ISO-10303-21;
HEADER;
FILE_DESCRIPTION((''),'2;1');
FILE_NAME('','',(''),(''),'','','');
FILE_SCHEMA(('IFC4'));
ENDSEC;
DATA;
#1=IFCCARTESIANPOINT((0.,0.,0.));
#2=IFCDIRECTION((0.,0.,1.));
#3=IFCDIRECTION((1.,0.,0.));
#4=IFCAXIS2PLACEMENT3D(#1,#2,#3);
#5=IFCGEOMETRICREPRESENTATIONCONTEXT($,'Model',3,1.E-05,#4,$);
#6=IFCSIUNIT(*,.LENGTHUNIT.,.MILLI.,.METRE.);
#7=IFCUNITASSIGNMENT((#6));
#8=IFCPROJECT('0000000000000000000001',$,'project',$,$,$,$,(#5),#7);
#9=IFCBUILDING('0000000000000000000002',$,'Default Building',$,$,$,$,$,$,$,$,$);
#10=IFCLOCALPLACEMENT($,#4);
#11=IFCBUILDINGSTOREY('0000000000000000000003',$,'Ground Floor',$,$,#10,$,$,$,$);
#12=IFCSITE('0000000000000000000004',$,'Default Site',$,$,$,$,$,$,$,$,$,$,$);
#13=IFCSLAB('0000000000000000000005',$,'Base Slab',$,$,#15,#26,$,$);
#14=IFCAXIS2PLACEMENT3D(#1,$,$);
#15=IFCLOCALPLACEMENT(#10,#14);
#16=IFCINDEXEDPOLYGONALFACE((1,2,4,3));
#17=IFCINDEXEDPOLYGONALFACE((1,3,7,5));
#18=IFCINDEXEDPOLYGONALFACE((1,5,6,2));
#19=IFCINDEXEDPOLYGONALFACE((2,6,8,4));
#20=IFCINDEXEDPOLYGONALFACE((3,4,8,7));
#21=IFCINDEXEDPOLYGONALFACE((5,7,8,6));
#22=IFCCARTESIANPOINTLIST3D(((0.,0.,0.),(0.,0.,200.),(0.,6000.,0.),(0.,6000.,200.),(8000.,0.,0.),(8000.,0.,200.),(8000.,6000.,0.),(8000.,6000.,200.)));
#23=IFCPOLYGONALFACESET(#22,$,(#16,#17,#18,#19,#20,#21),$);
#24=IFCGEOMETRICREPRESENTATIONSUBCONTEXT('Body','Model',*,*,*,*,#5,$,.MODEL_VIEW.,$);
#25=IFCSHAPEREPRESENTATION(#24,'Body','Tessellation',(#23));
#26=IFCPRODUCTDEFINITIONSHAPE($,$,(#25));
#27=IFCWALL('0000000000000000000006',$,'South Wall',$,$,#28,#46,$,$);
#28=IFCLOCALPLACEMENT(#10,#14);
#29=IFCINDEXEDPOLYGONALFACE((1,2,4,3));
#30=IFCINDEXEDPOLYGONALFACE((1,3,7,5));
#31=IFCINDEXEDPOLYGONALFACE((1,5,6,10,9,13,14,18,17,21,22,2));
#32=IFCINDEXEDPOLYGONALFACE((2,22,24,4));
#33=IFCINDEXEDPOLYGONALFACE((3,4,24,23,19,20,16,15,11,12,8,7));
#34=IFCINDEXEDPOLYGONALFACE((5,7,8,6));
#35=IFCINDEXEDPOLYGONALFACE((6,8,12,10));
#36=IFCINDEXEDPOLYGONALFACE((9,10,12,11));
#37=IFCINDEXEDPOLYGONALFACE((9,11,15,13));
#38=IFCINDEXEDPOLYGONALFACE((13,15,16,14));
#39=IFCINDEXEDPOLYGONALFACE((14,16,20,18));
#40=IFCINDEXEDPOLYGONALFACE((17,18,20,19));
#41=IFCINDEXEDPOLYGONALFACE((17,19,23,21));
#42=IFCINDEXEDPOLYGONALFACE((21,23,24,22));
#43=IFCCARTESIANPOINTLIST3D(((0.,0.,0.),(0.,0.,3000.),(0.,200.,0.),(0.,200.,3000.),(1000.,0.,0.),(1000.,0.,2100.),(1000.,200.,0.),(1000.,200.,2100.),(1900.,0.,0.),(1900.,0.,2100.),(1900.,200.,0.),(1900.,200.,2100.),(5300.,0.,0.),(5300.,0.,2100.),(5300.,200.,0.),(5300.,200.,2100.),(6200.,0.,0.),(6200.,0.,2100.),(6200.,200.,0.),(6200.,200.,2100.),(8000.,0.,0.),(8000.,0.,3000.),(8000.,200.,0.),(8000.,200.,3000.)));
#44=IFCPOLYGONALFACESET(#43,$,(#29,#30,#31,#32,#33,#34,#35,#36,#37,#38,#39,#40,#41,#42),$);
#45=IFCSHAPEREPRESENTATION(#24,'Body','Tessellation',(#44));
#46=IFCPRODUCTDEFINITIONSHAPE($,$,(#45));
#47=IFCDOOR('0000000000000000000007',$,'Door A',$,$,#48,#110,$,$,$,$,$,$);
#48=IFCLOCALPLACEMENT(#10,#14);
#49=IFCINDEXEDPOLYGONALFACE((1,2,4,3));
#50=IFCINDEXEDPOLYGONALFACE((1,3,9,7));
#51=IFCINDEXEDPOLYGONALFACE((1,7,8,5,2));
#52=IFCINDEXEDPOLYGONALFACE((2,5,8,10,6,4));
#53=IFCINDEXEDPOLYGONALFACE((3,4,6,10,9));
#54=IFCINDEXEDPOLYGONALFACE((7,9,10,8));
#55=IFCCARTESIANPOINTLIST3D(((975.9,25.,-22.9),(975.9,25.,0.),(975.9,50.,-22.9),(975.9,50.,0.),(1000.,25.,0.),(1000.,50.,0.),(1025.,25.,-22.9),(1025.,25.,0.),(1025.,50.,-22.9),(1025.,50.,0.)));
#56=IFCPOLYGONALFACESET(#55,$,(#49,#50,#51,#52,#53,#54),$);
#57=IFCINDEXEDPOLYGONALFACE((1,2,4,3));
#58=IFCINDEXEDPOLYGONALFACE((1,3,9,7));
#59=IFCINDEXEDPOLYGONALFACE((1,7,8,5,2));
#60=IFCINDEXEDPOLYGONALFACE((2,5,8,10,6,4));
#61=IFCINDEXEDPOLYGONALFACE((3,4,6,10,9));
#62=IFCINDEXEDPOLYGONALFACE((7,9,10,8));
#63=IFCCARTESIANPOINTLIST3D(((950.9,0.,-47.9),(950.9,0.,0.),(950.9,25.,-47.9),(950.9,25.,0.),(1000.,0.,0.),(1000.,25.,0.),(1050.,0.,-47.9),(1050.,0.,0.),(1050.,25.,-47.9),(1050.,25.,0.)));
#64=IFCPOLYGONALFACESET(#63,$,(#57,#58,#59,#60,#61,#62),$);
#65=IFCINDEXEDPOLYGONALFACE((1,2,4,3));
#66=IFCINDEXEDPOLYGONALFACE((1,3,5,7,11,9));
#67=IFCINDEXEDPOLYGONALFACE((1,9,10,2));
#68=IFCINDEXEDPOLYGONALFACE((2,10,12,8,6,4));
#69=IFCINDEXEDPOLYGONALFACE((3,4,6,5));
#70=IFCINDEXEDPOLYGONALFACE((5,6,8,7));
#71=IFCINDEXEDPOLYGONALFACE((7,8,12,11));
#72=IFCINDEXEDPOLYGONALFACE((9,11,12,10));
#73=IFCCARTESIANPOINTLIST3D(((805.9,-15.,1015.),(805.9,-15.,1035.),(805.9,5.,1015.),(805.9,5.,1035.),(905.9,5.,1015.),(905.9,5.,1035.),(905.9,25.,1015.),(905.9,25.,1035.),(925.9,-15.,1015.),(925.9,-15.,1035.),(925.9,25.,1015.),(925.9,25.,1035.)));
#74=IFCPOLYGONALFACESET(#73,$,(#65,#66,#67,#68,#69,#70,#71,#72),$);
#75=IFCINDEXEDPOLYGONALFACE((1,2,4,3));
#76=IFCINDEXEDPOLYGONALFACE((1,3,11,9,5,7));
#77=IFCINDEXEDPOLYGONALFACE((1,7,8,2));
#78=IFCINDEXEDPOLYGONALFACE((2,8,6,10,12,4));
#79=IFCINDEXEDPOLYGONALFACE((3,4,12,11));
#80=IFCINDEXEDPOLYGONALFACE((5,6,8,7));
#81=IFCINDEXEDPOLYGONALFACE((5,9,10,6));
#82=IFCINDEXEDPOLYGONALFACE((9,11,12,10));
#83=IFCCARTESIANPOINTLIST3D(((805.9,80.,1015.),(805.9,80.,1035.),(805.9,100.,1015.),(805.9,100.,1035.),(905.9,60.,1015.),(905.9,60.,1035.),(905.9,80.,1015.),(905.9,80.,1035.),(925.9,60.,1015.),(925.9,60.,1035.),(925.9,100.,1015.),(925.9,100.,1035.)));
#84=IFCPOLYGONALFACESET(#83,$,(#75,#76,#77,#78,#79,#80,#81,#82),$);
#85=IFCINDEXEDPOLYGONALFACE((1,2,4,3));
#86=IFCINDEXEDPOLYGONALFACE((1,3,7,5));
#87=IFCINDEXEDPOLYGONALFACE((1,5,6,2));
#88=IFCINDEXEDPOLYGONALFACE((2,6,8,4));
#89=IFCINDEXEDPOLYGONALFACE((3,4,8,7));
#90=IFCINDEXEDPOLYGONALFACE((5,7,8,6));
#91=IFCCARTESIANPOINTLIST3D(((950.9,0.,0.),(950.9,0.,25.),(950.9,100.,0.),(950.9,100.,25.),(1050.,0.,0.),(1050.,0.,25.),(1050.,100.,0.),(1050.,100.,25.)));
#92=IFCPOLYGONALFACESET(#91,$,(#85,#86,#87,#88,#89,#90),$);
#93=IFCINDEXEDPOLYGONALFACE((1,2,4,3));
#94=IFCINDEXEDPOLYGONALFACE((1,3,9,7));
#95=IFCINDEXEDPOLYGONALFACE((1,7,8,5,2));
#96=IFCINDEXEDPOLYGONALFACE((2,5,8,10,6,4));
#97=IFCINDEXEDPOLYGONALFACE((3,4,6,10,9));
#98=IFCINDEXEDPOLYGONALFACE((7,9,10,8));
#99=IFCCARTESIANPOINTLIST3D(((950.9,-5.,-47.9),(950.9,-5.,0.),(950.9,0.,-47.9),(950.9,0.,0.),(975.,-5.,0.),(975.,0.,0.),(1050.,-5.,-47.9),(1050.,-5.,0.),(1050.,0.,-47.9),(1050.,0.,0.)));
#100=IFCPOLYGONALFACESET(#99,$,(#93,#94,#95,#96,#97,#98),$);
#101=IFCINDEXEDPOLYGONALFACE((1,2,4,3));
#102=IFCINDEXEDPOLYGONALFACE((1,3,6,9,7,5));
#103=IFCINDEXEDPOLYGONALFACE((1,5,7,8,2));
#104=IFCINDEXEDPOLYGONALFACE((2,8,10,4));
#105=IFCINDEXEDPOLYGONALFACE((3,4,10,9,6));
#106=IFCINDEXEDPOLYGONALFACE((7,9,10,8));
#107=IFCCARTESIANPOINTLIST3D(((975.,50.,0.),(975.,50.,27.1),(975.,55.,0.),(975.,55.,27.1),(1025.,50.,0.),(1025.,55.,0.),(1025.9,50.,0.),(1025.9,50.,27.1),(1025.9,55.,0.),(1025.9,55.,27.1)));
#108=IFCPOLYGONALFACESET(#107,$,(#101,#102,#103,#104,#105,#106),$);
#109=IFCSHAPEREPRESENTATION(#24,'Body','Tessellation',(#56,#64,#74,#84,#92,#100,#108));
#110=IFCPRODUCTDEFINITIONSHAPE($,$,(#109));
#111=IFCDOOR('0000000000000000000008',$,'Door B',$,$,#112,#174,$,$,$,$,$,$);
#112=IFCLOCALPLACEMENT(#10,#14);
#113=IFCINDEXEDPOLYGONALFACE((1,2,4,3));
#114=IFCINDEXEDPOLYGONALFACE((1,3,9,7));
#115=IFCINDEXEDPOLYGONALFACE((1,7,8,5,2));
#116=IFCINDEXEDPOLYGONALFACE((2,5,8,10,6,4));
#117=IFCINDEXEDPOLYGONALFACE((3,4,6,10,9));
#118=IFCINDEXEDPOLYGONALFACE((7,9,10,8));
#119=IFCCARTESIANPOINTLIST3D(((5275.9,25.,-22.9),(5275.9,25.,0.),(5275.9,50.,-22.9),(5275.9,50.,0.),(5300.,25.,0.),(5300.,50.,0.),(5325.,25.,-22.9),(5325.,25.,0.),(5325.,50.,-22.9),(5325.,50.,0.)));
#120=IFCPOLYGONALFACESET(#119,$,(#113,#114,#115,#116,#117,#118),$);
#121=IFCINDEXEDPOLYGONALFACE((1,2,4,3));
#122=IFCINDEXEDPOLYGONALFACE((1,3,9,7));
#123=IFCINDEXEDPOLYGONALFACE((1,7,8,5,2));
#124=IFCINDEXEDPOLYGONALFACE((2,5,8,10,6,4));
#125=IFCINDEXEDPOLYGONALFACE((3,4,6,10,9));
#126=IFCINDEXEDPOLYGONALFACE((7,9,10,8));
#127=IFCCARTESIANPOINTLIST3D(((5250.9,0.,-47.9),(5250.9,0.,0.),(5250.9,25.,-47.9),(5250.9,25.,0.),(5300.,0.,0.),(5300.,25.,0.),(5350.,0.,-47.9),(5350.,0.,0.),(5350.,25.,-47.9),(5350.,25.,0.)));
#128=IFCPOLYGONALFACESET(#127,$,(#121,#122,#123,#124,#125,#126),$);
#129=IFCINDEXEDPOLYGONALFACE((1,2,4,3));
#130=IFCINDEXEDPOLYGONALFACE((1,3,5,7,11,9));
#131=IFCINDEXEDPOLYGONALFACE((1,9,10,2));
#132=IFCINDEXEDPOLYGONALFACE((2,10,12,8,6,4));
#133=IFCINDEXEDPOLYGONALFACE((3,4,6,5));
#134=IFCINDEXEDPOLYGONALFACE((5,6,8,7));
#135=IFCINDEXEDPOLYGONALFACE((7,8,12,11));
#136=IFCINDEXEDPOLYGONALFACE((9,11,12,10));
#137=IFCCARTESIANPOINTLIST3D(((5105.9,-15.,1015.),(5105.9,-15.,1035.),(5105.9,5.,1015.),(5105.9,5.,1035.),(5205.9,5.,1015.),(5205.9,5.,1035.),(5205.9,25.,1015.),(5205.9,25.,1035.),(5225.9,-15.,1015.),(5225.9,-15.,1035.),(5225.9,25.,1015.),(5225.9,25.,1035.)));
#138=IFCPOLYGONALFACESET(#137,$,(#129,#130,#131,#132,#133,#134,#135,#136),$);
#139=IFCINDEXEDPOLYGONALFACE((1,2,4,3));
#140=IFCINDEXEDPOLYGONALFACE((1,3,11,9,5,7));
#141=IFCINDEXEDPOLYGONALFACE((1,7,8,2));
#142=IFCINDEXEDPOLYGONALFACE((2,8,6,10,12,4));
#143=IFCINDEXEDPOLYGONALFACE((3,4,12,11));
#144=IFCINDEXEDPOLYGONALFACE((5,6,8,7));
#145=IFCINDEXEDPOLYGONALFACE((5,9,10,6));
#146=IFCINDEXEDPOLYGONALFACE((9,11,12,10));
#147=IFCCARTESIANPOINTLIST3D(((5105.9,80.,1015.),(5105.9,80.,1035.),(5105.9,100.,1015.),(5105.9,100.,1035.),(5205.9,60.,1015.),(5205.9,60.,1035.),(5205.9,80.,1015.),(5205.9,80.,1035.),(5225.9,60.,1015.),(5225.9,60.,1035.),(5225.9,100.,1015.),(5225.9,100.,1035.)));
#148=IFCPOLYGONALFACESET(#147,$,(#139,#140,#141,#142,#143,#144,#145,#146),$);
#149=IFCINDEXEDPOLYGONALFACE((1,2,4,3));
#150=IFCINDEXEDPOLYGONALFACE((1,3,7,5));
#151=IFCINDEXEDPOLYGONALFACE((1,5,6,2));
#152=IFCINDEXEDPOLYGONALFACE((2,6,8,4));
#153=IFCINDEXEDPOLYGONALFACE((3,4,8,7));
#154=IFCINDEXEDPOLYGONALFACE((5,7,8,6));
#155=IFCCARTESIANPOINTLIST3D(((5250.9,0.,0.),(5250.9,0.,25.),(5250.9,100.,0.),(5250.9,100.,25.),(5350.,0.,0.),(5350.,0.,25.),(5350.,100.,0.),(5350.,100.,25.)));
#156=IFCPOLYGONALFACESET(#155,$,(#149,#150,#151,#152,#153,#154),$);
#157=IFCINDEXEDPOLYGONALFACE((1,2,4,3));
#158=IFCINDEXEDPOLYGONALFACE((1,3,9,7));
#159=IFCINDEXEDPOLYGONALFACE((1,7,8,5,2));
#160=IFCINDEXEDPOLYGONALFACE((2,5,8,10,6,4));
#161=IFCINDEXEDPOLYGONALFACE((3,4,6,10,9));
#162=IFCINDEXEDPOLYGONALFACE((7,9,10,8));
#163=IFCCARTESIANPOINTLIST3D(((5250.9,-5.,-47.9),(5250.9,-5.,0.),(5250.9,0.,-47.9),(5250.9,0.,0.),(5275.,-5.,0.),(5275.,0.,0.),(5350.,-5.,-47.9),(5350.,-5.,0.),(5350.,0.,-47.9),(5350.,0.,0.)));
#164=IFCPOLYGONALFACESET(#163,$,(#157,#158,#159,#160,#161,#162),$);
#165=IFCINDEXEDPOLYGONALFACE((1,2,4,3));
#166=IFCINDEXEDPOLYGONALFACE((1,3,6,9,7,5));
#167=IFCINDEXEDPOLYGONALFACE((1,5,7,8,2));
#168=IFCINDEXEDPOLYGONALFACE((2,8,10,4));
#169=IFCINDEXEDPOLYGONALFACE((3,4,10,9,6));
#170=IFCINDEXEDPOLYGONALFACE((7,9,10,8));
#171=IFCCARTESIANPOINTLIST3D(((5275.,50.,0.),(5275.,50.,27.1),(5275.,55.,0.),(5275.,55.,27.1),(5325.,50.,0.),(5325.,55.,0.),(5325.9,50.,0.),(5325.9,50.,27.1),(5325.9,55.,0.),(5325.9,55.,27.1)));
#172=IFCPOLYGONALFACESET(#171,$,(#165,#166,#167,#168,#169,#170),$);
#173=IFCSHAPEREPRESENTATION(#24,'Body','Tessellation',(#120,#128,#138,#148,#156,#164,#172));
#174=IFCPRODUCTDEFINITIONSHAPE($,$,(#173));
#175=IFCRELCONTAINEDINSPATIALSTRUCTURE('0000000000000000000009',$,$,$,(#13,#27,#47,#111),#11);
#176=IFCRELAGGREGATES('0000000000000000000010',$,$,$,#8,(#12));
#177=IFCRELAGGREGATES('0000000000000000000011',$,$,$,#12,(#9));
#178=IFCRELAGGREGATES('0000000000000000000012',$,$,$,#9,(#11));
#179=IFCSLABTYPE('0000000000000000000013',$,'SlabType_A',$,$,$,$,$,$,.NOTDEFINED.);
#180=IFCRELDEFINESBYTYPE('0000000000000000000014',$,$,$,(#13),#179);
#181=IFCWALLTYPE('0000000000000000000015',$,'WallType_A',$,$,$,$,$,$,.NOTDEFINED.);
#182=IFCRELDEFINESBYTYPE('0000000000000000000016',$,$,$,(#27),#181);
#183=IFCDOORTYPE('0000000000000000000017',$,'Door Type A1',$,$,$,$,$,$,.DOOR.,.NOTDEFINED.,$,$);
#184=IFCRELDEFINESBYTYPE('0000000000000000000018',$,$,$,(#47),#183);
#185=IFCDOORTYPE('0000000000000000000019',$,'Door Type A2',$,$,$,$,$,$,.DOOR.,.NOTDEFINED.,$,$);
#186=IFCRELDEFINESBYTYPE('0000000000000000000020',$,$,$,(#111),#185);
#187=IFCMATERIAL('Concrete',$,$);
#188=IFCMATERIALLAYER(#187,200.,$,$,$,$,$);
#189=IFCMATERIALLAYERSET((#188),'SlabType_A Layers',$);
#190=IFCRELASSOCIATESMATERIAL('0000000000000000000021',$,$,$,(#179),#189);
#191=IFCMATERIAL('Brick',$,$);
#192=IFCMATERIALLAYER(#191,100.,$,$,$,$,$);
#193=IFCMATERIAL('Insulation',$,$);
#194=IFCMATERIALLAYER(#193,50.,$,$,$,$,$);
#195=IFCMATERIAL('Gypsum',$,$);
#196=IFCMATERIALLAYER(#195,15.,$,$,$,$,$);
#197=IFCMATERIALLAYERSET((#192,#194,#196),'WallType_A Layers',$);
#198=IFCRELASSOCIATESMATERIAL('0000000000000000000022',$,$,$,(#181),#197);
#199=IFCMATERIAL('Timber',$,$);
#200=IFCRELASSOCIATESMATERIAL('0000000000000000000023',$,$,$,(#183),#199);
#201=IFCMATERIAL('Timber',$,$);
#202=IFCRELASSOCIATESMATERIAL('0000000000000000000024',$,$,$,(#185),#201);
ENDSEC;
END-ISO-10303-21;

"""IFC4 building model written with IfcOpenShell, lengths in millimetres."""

from ifc_helpers import new_model, si_unit, frame, origin_with_axes, place, context, subcontext, project, spatial, line, indexed_curve, outline, extrude, material, layer, layer_set, type_object, element, fill, save


model = new_model("IFC4")

# Units and contexts
model_context = context("Model", 3, precision=1e-05, world=origin_with_axes())
body_context = subcontext(model_context, "Body", "Model", "MODEL_VIEW")
ifc_project = project(units=[si_unit("LENGTHUNIT", "METRE", prefix="MILLI")], contexts=[model_context])

# Site, building, storey
site = spatial("IfcSite", under=ifc_project, Name="Default Site")
building = spatial("IfcBuilding", under=site, Name="Default Building")
storey_placement = place(None, origin_with_axes())
storey = spatial("IfcBuildingStorey", under=building, at=storey_placement, Name="Ground Floor")

# Slab
ifc_material_1 = material(Name="Concrete")
ifc_layer_1 = layer(ifc_material_1, 200.0)
ifc_layer_set_1 = layer_set([ifc_layer_1], Name="SlabType_A Layers")
slab_type = type_object("IfcSlabType", Name="SlabType_A", PredefinedType="NOTDEFINED", material=ifc_layer_set_1)
slab_placement = place(storey_placement, origin_with_axes())
element("IfcSlab", 1, at=slab_placement, inside=storey, type_object=slab_type, Name="Base Slab", context=body_context, shape_type="SweptSolid", body=[
    extrude(outline(indexed_curve([(0.0, 0.0), (8000.0, 0.0), (8000.0, 6000.0), (0.0, 6000.0), (0.0, 0.0)])), None, (0.0, 0.0, 1.0), 200.0),
])

# Wall, openings, doors
ifc_material_2 = material(Name="Brick")
ifc_layer_2 = layer(ifc_material_2, 100.0)
ifc_material_3 = material(Name="Insulation")
ifc_layer_3 = layer(ifc_material_3, 50.0)
ifc_material_4 = material(Name="Gypsum")
ifc_layer_4 = layer(ifc_material_4, 15.0)
ifc_layer_set_2 = layer_set([ifc_layer_2, ifc_layer_3, ifc_layer_4], Name="WallType_A Layers")
wall_type_1 = type_object("IfcWallType", Name="WallType_A", PredefinedType="NOTDEFINED", material=ifc_layer_set_2)
wall_1_placement = place(storey_placement, origin_with_axes())
wall_1 = element("IfcWall", 2, at=wall_1_placement, inside=storey, type_object=wall_type_1, Name="South Wall", context=body_context, shape_type="SweptSolid", body=[
    extrude(outline(indexed_curve([(0.0, 0.0), (8000.0, 0.0), (8000.0, 200.0), (0.0, 200.0), (0.0, 0.0)])), None, (0.0, 0.0, 1.0), 3000.0),
])
opening_1_placement = place(wall_1_placement, origin_with_axes())
opening_1 = element("IfcOpeningElement", 3, at=opening_1_placement, cuts=wall_1, context=body_context, shape_type="SweptSolid", body=[
    extrude(outline(indexed_curve([(1000.0, 0.0), (1900.0, 0.0), (1900.0, 200.0), (1000.0, 200.0), (1000.0, 0.0)])), None, (0.0, 0.0, 1.0), 2100.0),
])
opening_2_placement = place(wall_1_placement, origin_with_axes())
opening_2 = element("IfcOpeningElement", 4, at=opening_2_placement, cuts=wall_1, context=body_context, shape_type="SweptSolid", body=[
    extrude(outline(indexed_curve([(5300.0, 0.0), (6200.0, 0.0), (6200.0, 200.0), (5300.0, 200.0), (5300.0, 0.0)])), None, (0.0, 0.0, 1.0), 2100.0),
])
ifc_material_5 = material(Name="Timber")
door_type_1 = type_object("IfcDoorType", Name="Door Type A1", OperationType="NOTDEFINED", PredefinedType="DOOR", material=ifc_material_5)
door_1_placement = place(storey_placement, frame((1000.0, 0.0, 0.0), z_axis=(0.0, 0.0, 1.0), x_axis=(1.0, 0.0, 0.0)))
door_1 = element("IfcDoor", 5, at=door_1_placement, inside=storey, type_object=door_type_1, Name="Door A", context=body_context, shape_type="SweptSolid", body=[
    extrude(outline(indexed_curve([(0.0, 0.0), (0.0, 2.1), (0.9, 2.1), (0.9, 0.0), (-24.1, 0.0), (-24.1, -22.9), (25.0, -22.9), (25.0, 0.0)], segments=[line(1, 2, 3, 4, 5, 6, 7, 8, 1)])), frame((0.0, 25.0, 0.0), z_axis=(0.0, -1.0, 0.0), x_axis=(1.0, 0.0, 0.0)), (0.0, 0.0, -1.0), 25.0),
    extrude(outline(indexed_curve([(0.0, 0.0), (0.0, 2.1), (0.9, 2.1), (0.9, 0.0), (-49.1, 0.0), (-49.1, -47.9), (50.0, -47.9), (50.0, 0.0)], segments=[line(1, 2, 3, 4, 5, 6, 7, 8, 1)])), frame((0.0, 0.0, 0.0), z_axis=(0.0, -1.0, 0.0), x_axis=(1.0, 0.0, 0.0)), (0.0, 0.0, -1.0), 25.0),
    extrude(outline(indexed_curve([(0.0, 0.0), (-49.1, 0.0), (-49.1, 35.0), (0.0, 35.0)], segments=[line(1, 2, 3, 4, 1)])), frame((25.0, 25.0, 25.0), z_axis=(0.0, 0.0, 1.0), x_axis=(1.0, 0.0, 0.0)), (0.0, 0.0, 1.0), -47.9),
    extrude(outline(indexed_curve([(0.0, 0.0), (0.0, -40.0), (-120.0, -40.0), (-120.0, -20.0), (-20.0, -20.0), (-20.0, 0.0)], segments=[line(1, 2, 3, 4, 5, 6, 1)])), frame((-74.1, 25.0, 1015.0), z_axis=(0.0, 0.0, 1.0), x_axis=(1.0, 0.0, 0.0)), (0.0, 0.0, 1.0), 20.0),
    extrude(outline(indexed_curve([(0.0, 0.0), (0.0, 40.0), (-120.0, 40.0), (-120.0, 20.0), (-20.0, 20.0), (-20.0, 0.0)], segments=[line(1, 2, 3, 4, 5, 6, 1)])), frame((-74.1, 60.0, 1015.0), z_axis=(0.0, 0.0, 1.0), x_axis=(1.0, 0.0, 0.0)), (0.0, 0.0, 1.0), 20.0),
    extrude(outline(indexed_curve([(0.0, 0.0), (-99.1, 0.0), (-99.1, 100.0), (0.0, 100.0)], segments=[line(1, 2, 3, 4, 1)])), frame((50.0, 0.0, 0.0), z_axis=(0.0, 0.0, 1.0), x_axis=(1.0, 0.0, 0.0)), (0.0, 0.0, 1.0), 25.0),
    extrude(outline(indexed_curve([(0.0, 0.0), (0.0, 27.1), (50.9, 27.1), (50.9, 0.0), (-24.1, 0.0), (-24.1, -47.9), (75.0, -47.9), (75.0, 0.0)], segments=[line(1, 2, 3, 4, 5, 6, 7, 8, 1)])), frame((-25.0, -5.0, 0.0), z_axis=(0.0, -1.0, 0.0), x_axis=(1.0, 0.0, 0.0)), (0.0, 0.0, -1.0), 5.0),
    extrude(outline(indexed_curve([(0.0, 0.0), (0.0, 27.1), (50.9, 27.1), (50.9, 0.0), (0.9, 0.0), (0.9, -22.9), (50.0, -22.9), (50.0, 0.0)], segments=[line(1, 2, 3, 4, 5, 6, 7, 8, 1)])), frame((-25.0, 50.0, 0.0), z_axis=(0.0, -1.0, 0.0), x_axis=(1.0, 0.0, 0.0)), (0.0, 0.0, -1.0), 5.0),
])
fill(opening_1, door_1)
ifc_material_6 = material(Name="Timber")
door_type_2 = type_object("IfcDoorType", Name="Door Type A2", OperationType="NOTDEFINED", PredefinedType="DOOR", material=ifc_material_6)
door_2_placement = place(storey_placement, frame((5300.0, 0.0, 0.0), z_axis=(0.0, 0.0, 1.0), x_axis=(1.0, 0.0, 0.0)))
door_2 = element("IfcDoor", 6, at=door_2_placement, inside=storey, type_object=door_type_2, Name="Door B", context=body_context, shape_type="SweptSolid", body=[
    extrude(outline(indexed_curve([(0.0, 0.0), (0.0, 2.1), (0.9, 2.1), (0.9, 0.0), (-24.1, 0.0), (-24.1, -22.9), (25.0, -22.9), (25.0, 0.0)], segments=[line(1, 2, 3, 4, 5, 6, 7, 8, 1)])), frame((0.0, 25.0, 0.0), z_axis=(0.0, -1.0, 0.0), x_axis=(1.0, 0.0, 0.0)), (0.0, 0.0, -1.0), 25.0),
    extrude(outline(indexed_curve([(0.0, 0.0), (0.0, 2.1), (0.9, 2.1), (0.9, 0.0), (-49.1, 0.0), (-49.1, -47.9), (50.0, -47.9), (50.0, 0.0)], segments=[line(1, 2, 3, 4, 5, 6, 7, 8, 1)])), frame((0.0, 0.0, 0.0), z_axis=(0.0, -1.0, 0.0), x_axis=(1.0, 0.0, 0.0)), (0.0, 0.0, -1.0), 25.0),
    extrude(outline(indexed_curve([(0.0, 0.0), (-49.1, 0.0), (-49.1, 35.0), (0.0, 35.0)], segments=[line(1, 2, 3, 4, 1)])), frame((25.0, 25.0, 25.0), z_axis=(0.0, 0.0, 1.0), x_axis=(1.0, 0.0, 0.0)), (0.0, 0.0, 1.0), -47.9),
    extrude(outline(indexed_curve([(0.0, 0.0), (0.0, -40.0), (-120.0, -40.0), (-120.0, -20.0), (-20.0, -20.0), (-20.0, 0.0)], segments=[line(1, 2, 3, 4, 5, 6, 1)])), frame((-74.1, 25.0, 1015.0), z_axis=(0.0, 0.0, 1.0), x_axis=(1.0, 0.0, 0.0)), (0.0, 0.0, 1.0), 20.0),
    extrude(outline(indexed_curve([(0.0, 0.0), (0.0, 40.0), (-120.0, 40.0), (-120.0, 20.0), (-20.0, 20.0), (-20.0, 0.0)], segments=[line(1, 2, 3, 4, 5, 6, 1)])), frame((-74.1, 60.0, 1015.0), z_axis=(0.0, 0.0, 1.0), x_axis=(1.0, 0.0, 0.0)), (0.0, 0.0, 1.0), 20.0),
    extrude(outline(indexed_curve([(0.0, 0.0), (-99.1, 0.0), (-99.1, 100.0), (0.0, 100.0)], segments=[line(1, 2, 3, 4, 1)])), frame((50.0, 0.0, 0.0), z_axis=(0.0, 0.0, 1.0), x_axis=(1.0, 0.0, 0.0)), (0.0, 0.0, 1.0), 25.0),
    extrude(outline(indexed_curve([(0.0, 0.0), (0.0, 27.1), (50.9, 27.1), (50.9, 0.0), (-24.1, 0.0), (-24.1, -47.9), (75.0, -47.9), (75.0, 0.0)], segments=[line(1, 2, 3, 4, 5, 6, 7, 8, 1)])), frame((-25.0, -5.0, 0.0), z_axis=(0.0, -1.0, 0.0), x_axis=(1.0, 0.0, 0.0)), (0.0, 0.0, -1.0), 5.0),
    extrude(outline(indexed_curve([(0.0, 0.0), (0.0, 27.1), (50.9, 27.1), (50.9, 0.0), (0.9, 0.0), (0.9, -22.9), (50.0, -22.9), (50.0, 0.0)], segments=[line(1, 2, 3, 4, 5, 6, 7, 8, 1)])), frame((-25.0, 50.0, 0.0), z_axis=(0.0, -1.0, 0.0), x_axis=(1.0, 0.0, 0.0)), (0.0, 0.0, -1.0), 5.0),
])
fill(opening_2, door_2)

save(model, "model.ifc")
